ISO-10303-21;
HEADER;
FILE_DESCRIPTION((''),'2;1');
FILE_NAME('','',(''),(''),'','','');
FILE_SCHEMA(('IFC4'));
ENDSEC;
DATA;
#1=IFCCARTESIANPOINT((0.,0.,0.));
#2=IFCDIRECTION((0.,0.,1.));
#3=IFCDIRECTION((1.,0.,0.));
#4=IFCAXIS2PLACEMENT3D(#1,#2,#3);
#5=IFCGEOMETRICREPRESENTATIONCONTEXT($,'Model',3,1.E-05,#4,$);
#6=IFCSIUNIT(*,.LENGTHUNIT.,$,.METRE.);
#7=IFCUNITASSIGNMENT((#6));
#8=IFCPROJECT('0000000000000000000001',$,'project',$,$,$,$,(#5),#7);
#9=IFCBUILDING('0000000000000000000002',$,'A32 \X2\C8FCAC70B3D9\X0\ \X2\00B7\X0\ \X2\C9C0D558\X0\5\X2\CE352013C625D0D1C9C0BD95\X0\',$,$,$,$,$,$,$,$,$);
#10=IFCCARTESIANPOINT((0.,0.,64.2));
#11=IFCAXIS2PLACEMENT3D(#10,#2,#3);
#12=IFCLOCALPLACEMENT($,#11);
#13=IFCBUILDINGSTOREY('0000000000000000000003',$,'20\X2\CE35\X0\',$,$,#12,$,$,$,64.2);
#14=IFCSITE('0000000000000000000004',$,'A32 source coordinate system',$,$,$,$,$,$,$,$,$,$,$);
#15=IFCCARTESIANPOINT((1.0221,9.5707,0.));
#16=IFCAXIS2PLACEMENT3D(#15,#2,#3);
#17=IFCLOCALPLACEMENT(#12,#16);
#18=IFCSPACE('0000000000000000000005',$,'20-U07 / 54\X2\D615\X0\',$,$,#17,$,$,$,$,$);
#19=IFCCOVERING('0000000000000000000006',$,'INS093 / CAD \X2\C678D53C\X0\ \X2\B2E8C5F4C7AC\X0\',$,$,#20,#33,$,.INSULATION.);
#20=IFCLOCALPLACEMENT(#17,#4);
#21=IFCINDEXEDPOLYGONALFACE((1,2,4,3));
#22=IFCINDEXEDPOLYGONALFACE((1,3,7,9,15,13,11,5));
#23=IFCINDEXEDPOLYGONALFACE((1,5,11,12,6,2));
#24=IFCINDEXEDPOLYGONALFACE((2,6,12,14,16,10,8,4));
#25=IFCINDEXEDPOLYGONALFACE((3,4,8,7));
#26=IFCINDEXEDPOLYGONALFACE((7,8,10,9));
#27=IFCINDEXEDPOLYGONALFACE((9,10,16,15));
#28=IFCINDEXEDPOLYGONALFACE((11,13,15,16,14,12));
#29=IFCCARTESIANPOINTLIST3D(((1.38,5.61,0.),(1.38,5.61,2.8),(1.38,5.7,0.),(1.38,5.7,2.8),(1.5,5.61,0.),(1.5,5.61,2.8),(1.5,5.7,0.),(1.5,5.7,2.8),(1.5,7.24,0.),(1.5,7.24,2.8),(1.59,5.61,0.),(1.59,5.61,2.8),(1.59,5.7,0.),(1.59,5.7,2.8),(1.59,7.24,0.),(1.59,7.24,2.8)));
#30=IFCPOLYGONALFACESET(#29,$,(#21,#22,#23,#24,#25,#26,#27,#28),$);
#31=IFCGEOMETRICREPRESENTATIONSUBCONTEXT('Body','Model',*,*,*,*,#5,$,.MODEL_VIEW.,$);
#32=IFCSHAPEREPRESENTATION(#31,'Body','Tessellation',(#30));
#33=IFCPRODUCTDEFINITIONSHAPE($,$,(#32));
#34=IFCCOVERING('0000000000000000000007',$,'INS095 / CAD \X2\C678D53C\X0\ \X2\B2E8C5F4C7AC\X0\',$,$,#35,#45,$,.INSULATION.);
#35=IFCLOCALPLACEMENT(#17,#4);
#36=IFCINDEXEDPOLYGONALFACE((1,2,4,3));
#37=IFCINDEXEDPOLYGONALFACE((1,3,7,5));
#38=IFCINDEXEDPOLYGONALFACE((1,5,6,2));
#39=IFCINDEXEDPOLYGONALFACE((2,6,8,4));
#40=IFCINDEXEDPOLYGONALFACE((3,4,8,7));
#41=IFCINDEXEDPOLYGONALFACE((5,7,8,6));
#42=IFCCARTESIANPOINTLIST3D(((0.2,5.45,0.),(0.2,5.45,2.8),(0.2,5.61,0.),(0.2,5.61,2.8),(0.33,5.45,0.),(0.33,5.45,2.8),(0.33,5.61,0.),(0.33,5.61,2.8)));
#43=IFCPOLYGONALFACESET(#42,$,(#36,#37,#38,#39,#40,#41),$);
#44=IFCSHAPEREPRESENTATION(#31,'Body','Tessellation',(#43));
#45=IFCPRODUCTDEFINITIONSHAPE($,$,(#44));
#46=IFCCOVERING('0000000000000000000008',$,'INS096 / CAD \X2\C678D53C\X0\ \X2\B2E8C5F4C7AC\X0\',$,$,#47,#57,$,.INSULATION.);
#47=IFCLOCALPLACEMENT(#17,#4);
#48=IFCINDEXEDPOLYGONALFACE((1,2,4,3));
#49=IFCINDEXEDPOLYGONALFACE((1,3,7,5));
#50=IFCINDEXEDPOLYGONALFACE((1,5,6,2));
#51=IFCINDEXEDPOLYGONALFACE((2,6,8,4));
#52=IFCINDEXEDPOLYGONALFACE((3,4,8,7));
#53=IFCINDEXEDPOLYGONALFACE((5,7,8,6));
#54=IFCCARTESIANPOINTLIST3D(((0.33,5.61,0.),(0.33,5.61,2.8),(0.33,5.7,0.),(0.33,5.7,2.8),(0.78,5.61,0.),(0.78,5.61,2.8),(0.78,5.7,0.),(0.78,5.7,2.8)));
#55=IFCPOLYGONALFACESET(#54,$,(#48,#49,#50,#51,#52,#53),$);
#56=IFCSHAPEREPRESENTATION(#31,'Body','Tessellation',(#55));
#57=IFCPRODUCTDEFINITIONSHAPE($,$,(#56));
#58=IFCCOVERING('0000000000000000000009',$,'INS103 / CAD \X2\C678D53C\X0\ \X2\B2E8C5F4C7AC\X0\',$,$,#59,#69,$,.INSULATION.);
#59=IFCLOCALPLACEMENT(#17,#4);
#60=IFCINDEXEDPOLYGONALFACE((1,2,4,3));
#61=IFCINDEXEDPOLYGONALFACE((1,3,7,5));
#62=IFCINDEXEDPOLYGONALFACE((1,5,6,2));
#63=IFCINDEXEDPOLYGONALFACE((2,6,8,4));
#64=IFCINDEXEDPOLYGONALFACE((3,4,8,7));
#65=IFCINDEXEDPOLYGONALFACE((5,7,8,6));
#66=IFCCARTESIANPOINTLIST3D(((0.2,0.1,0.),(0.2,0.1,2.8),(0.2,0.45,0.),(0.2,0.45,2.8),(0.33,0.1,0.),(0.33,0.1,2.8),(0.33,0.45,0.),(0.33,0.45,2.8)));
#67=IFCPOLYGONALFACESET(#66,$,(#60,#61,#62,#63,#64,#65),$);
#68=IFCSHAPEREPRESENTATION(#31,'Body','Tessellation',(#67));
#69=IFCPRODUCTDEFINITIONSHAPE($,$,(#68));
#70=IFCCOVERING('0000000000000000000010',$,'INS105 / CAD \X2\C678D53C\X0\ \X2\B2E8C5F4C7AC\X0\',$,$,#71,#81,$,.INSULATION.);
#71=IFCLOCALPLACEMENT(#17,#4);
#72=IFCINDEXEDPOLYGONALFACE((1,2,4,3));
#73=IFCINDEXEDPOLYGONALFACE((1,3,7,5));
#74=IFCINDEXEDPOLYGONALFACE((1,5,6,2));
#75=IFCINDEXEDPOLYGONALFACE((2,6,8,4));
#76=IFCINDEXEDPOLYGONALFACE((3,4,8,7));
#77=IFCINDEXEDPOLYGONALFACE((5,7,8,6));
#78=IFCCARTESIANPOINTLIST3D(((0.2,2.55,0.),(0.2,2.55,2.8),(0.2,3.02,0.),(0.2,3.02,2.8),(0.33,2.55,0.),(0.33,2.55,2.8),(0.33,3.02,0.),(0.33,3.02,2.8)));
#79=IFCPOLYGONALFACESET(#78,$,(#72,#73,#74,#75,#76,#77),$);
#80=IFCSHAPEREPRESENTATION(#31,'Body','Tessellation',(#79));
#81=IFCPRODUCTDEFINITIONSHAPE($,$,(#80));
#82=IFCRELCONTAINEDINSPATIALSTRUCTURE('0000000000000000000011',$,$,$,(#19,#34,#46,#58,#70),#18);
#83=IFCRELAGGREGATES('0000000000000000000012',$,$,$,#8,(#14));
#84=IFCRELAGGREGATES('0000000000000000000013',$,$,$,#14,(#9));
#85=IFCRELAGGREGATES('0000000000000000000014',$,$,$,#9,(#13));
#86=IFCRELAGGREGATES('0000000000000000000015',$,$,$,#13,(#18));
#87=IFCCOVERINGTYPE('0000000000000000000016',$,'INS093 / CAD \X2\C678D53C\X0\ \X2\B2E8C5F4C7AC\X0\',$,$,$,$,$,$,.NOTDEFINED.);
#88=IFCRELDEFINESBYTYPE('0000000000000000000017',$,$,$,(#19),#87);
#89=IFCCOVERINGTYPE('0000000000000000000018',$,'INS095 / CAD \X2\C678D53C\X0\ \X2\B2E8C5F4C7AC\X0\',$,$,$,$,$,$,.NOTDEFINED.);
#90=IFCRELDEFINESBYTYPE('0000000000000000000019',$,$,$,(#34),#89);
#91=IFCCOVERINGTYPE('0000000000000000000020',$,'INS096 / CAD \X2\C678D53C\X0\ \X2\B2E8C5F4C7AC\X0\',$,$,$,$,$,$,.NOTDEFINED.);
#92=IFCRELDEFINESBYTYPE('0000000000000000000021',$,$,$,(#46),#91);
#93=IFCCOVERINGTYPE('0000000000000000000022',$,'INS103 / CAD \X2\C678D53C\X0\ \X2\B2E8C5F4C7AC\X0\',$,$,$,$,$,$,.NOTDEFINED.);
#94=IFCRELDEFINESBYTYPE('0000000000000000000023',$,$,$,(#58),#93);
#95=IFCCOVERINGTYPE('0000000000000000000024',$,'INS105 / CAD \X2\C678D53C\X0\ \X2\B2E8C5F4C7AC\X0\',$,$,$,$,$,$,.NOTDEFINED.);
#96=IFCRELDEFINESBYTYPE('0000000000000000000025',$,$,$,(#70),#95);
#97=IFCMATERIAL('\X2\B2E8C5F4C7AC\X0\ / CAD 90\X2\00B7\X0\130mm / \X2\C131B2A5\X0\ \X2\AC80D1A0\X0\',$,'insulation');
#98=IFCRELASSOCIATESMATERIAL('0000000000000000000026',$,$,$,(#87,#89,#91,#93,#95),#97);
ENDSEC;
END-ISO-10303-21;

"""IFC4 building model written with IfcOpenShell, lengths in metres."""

from ifc_helpers import new_model, si_unit, frame, origin, origin_with_axes, place, context, subcontext, project, spatial, polyline, outline, extrude, source, transform, mapped, material, type_object, type_shapes, element, save


model = new_model("IFC4")

# Units and contexts
model_context = context("Model", 3, precision=1e-05, world=origin_with_axes())
body_context = subcontext(model_context, "Body", "Model", "MODEL_VIEW")
ifc_project = project(units=[si_unit("LENGTHUNIT", "METRE")], contexts=[model_context])

# Site, building, storey, space
storey_placement = place(None, frame((0.0, 0.0, 64.2), z_axis=(0.0, 0.0, 1.0), x_axis=(1.0, 0.0, 0.0)))
space_placement = place(storey_placement, frame((1.0221, 9.5707, 0.0), z_axis=(0.0, 0.0, 1.0), x_axis=(1.0, 0.0, 0.0)))
site = spatial("IfcSite", under=ifc_project, Name="A32 source coordinate system")
building = spatial("IfcBuilding", under=site, Name="A32 주거동 · 지하5층–옥탑지붕")
storey = spatial("IfcBuildingStorey", under=building, at=storey_placement, Name="20층", Elevation=64.2)
space = spatial("IfcSpace", under=storey, at=space_placement, Name="20-U07 / 54형")

# Coverings
ifc_material = material(Name="단열재 / CAD 90·130mm / 성능 검토", Category="insulation")
covering_type_1 = type_object("IfcCoveringType", Name="INS093 / CAD 외피 단열재", PredefinedType="NOTDEFINED", material=ifc_material)
shared_shape_1 = source(origin(), body_context, "Body", "SweptSolid", [
    extrude(outline(polyline([(1.5, 5.7), (1.5, 7.24), (1.59, 7.24), (1.59, 5.7), (1.59, 5.61), (1.5, 5.61), (1.38, 5.61), (1.38, 5.7), (1.5, 5.7)])), origin(), (0.0, 0.0, 1.0), 2.8),
])
type_shapes(covering_type_1, [shared_shape_1])
covering_1_placement = place(space_placement, origin_with_axes())
element("IfcCovering", 1, at=covering_1_placement, inside=space, type_object=covering_type_1, Name="INS093 / CAD 외피 단열재", PredefinedType="INSULATION", context=body_context, shape_type="MappedRepresentation", body=[
    mapped(shared_shape_1, transform((0.0, 0.0, 0.0), scale=1.0)),
])
covering_type_2 = type_object("IfcCoveringType", Name="INS095 / CAD 외피 단열재", PredefinedType="NOTDEFINED", material=ifc_material)
shared_shape_2 = source(origin(), body_context, "Body", "SweptSolid", [
    extrude(outline(polyline([(0.2, 5.61), (0.33, 5.61), (0.33, 5.45), (0.2, 5.45), (0.2, 5.61)])), origin(), (0.0, 0.0, 1.0), 2.8),
])
type_shapes(covering_type_2, [shared_shape_2])
covering_2_placement = place(space_placement, origin_with_axes())
element("IfcCovering", 2, at=covering_2_placement, inside=space, type_object=covering_type_2, Name="INS095 / CAD 외피 단열재", PredefinedType="INSULATION", context=body_context, shape_type="MappedRepresentation", body=[
    mapped(shared_shape_2, transform((0.0, 0.0, 0.0), scale=1.0)),
])
covering_type_3 = type_object("IfcCoveringType", Name="INS096 / CAD 외피 단열재", PredefinedType="NOTDEFINED", material=ifc_material)
shared_shape_3 = source(origin(), body_context, "Body", "SweptSolid", [
    extrude(outline(polyline([(0.78, 5.7), (0.78, 5.61), (0.33, 5.61), (0.33, 5.7), (0.78, 5.7)])), origin(), (0.0, 0.0, 1.0), 2.8),
])
type_shapes(covering_type_3, [shared_shape_3])
covering_3_placement = place(space_placement, origin_with_axes())
element("IfcCovering", 3, at=covering_3_placement, inside=space, type_object=covering_type_3, Name="INS096 / CAD 외피 단열재", PredefinedType="INSULATION", context=body_context, shape_type="MappedRepresentation", body=[
    mapped(shared_shape_3, transform((0.0, 0.0, 0.0), scale=1.0)),
])
covering_type_4 = type_object("IfcCoveringType", Name="INS103 / CAD 외피 단열재", PredefinedType="NOTDEFINED", material=ifc_material)
shared_shape_4 = source(origin(), body_context, "Body", "SweptSolid", [
    extrude(outline(polyline([(0.2, 0.45), (0.33, 0.45), (0.33, 0.1), (0.2, 0.1), (0.2, 0.45)])), origin(), (0.0, 0.0, 1.0), 2.8),
])
type_shapes(covering_type_4, [shared_shape_4])
covering_4_placement = place(space_placement, origin_with_axes())
element("IfcCovering", 4, at=covering_4_placement, inside=space, type_object=covering_type_4, Name="INS103 / CAD 외피 단열재", PredefinedType="INSULATION", context=body_context, shape_type="MappedRepresentation", body=[
    mapped(shared_shape_4, transform((0.0, 0.0, 0.0), scale=1.0)),
])
covering_type_5 = type_object("IfcCoveringType", Name="INS105 / CAD 외피 단열재", PredefinedType="NOTDEFINED", material=ifc_material)
shared_shape_5 = source(origin(), body_context, "Body", "SweptSolid", [
    extrude(outline(polyline([(0.2, 3.02), (0.33, 3.02), (0.33, 2.55), (0.2, 2.55), (0.2, 3.02)])), origin(), (0.0, 0.0, 1.0), 2.8),
])
type_shapes(covering_type_5, [shared_shape_5])
covering_5_placement = place(space_placement, origin_with_axes())
element("IfcCovering", 5, at=covering_5_placement, inside=space, type_object=covering_type_5, Name="INS105 / CAD 외피 단열재", PredefinedType="INSULATION", context=body_context, shape_type="MappedRepresentation", body=[
    mapped(shared_shape_5, transform((0.0, 0.0, 0.0), scale=1.0)),
])

save(model, "model.ifc")
